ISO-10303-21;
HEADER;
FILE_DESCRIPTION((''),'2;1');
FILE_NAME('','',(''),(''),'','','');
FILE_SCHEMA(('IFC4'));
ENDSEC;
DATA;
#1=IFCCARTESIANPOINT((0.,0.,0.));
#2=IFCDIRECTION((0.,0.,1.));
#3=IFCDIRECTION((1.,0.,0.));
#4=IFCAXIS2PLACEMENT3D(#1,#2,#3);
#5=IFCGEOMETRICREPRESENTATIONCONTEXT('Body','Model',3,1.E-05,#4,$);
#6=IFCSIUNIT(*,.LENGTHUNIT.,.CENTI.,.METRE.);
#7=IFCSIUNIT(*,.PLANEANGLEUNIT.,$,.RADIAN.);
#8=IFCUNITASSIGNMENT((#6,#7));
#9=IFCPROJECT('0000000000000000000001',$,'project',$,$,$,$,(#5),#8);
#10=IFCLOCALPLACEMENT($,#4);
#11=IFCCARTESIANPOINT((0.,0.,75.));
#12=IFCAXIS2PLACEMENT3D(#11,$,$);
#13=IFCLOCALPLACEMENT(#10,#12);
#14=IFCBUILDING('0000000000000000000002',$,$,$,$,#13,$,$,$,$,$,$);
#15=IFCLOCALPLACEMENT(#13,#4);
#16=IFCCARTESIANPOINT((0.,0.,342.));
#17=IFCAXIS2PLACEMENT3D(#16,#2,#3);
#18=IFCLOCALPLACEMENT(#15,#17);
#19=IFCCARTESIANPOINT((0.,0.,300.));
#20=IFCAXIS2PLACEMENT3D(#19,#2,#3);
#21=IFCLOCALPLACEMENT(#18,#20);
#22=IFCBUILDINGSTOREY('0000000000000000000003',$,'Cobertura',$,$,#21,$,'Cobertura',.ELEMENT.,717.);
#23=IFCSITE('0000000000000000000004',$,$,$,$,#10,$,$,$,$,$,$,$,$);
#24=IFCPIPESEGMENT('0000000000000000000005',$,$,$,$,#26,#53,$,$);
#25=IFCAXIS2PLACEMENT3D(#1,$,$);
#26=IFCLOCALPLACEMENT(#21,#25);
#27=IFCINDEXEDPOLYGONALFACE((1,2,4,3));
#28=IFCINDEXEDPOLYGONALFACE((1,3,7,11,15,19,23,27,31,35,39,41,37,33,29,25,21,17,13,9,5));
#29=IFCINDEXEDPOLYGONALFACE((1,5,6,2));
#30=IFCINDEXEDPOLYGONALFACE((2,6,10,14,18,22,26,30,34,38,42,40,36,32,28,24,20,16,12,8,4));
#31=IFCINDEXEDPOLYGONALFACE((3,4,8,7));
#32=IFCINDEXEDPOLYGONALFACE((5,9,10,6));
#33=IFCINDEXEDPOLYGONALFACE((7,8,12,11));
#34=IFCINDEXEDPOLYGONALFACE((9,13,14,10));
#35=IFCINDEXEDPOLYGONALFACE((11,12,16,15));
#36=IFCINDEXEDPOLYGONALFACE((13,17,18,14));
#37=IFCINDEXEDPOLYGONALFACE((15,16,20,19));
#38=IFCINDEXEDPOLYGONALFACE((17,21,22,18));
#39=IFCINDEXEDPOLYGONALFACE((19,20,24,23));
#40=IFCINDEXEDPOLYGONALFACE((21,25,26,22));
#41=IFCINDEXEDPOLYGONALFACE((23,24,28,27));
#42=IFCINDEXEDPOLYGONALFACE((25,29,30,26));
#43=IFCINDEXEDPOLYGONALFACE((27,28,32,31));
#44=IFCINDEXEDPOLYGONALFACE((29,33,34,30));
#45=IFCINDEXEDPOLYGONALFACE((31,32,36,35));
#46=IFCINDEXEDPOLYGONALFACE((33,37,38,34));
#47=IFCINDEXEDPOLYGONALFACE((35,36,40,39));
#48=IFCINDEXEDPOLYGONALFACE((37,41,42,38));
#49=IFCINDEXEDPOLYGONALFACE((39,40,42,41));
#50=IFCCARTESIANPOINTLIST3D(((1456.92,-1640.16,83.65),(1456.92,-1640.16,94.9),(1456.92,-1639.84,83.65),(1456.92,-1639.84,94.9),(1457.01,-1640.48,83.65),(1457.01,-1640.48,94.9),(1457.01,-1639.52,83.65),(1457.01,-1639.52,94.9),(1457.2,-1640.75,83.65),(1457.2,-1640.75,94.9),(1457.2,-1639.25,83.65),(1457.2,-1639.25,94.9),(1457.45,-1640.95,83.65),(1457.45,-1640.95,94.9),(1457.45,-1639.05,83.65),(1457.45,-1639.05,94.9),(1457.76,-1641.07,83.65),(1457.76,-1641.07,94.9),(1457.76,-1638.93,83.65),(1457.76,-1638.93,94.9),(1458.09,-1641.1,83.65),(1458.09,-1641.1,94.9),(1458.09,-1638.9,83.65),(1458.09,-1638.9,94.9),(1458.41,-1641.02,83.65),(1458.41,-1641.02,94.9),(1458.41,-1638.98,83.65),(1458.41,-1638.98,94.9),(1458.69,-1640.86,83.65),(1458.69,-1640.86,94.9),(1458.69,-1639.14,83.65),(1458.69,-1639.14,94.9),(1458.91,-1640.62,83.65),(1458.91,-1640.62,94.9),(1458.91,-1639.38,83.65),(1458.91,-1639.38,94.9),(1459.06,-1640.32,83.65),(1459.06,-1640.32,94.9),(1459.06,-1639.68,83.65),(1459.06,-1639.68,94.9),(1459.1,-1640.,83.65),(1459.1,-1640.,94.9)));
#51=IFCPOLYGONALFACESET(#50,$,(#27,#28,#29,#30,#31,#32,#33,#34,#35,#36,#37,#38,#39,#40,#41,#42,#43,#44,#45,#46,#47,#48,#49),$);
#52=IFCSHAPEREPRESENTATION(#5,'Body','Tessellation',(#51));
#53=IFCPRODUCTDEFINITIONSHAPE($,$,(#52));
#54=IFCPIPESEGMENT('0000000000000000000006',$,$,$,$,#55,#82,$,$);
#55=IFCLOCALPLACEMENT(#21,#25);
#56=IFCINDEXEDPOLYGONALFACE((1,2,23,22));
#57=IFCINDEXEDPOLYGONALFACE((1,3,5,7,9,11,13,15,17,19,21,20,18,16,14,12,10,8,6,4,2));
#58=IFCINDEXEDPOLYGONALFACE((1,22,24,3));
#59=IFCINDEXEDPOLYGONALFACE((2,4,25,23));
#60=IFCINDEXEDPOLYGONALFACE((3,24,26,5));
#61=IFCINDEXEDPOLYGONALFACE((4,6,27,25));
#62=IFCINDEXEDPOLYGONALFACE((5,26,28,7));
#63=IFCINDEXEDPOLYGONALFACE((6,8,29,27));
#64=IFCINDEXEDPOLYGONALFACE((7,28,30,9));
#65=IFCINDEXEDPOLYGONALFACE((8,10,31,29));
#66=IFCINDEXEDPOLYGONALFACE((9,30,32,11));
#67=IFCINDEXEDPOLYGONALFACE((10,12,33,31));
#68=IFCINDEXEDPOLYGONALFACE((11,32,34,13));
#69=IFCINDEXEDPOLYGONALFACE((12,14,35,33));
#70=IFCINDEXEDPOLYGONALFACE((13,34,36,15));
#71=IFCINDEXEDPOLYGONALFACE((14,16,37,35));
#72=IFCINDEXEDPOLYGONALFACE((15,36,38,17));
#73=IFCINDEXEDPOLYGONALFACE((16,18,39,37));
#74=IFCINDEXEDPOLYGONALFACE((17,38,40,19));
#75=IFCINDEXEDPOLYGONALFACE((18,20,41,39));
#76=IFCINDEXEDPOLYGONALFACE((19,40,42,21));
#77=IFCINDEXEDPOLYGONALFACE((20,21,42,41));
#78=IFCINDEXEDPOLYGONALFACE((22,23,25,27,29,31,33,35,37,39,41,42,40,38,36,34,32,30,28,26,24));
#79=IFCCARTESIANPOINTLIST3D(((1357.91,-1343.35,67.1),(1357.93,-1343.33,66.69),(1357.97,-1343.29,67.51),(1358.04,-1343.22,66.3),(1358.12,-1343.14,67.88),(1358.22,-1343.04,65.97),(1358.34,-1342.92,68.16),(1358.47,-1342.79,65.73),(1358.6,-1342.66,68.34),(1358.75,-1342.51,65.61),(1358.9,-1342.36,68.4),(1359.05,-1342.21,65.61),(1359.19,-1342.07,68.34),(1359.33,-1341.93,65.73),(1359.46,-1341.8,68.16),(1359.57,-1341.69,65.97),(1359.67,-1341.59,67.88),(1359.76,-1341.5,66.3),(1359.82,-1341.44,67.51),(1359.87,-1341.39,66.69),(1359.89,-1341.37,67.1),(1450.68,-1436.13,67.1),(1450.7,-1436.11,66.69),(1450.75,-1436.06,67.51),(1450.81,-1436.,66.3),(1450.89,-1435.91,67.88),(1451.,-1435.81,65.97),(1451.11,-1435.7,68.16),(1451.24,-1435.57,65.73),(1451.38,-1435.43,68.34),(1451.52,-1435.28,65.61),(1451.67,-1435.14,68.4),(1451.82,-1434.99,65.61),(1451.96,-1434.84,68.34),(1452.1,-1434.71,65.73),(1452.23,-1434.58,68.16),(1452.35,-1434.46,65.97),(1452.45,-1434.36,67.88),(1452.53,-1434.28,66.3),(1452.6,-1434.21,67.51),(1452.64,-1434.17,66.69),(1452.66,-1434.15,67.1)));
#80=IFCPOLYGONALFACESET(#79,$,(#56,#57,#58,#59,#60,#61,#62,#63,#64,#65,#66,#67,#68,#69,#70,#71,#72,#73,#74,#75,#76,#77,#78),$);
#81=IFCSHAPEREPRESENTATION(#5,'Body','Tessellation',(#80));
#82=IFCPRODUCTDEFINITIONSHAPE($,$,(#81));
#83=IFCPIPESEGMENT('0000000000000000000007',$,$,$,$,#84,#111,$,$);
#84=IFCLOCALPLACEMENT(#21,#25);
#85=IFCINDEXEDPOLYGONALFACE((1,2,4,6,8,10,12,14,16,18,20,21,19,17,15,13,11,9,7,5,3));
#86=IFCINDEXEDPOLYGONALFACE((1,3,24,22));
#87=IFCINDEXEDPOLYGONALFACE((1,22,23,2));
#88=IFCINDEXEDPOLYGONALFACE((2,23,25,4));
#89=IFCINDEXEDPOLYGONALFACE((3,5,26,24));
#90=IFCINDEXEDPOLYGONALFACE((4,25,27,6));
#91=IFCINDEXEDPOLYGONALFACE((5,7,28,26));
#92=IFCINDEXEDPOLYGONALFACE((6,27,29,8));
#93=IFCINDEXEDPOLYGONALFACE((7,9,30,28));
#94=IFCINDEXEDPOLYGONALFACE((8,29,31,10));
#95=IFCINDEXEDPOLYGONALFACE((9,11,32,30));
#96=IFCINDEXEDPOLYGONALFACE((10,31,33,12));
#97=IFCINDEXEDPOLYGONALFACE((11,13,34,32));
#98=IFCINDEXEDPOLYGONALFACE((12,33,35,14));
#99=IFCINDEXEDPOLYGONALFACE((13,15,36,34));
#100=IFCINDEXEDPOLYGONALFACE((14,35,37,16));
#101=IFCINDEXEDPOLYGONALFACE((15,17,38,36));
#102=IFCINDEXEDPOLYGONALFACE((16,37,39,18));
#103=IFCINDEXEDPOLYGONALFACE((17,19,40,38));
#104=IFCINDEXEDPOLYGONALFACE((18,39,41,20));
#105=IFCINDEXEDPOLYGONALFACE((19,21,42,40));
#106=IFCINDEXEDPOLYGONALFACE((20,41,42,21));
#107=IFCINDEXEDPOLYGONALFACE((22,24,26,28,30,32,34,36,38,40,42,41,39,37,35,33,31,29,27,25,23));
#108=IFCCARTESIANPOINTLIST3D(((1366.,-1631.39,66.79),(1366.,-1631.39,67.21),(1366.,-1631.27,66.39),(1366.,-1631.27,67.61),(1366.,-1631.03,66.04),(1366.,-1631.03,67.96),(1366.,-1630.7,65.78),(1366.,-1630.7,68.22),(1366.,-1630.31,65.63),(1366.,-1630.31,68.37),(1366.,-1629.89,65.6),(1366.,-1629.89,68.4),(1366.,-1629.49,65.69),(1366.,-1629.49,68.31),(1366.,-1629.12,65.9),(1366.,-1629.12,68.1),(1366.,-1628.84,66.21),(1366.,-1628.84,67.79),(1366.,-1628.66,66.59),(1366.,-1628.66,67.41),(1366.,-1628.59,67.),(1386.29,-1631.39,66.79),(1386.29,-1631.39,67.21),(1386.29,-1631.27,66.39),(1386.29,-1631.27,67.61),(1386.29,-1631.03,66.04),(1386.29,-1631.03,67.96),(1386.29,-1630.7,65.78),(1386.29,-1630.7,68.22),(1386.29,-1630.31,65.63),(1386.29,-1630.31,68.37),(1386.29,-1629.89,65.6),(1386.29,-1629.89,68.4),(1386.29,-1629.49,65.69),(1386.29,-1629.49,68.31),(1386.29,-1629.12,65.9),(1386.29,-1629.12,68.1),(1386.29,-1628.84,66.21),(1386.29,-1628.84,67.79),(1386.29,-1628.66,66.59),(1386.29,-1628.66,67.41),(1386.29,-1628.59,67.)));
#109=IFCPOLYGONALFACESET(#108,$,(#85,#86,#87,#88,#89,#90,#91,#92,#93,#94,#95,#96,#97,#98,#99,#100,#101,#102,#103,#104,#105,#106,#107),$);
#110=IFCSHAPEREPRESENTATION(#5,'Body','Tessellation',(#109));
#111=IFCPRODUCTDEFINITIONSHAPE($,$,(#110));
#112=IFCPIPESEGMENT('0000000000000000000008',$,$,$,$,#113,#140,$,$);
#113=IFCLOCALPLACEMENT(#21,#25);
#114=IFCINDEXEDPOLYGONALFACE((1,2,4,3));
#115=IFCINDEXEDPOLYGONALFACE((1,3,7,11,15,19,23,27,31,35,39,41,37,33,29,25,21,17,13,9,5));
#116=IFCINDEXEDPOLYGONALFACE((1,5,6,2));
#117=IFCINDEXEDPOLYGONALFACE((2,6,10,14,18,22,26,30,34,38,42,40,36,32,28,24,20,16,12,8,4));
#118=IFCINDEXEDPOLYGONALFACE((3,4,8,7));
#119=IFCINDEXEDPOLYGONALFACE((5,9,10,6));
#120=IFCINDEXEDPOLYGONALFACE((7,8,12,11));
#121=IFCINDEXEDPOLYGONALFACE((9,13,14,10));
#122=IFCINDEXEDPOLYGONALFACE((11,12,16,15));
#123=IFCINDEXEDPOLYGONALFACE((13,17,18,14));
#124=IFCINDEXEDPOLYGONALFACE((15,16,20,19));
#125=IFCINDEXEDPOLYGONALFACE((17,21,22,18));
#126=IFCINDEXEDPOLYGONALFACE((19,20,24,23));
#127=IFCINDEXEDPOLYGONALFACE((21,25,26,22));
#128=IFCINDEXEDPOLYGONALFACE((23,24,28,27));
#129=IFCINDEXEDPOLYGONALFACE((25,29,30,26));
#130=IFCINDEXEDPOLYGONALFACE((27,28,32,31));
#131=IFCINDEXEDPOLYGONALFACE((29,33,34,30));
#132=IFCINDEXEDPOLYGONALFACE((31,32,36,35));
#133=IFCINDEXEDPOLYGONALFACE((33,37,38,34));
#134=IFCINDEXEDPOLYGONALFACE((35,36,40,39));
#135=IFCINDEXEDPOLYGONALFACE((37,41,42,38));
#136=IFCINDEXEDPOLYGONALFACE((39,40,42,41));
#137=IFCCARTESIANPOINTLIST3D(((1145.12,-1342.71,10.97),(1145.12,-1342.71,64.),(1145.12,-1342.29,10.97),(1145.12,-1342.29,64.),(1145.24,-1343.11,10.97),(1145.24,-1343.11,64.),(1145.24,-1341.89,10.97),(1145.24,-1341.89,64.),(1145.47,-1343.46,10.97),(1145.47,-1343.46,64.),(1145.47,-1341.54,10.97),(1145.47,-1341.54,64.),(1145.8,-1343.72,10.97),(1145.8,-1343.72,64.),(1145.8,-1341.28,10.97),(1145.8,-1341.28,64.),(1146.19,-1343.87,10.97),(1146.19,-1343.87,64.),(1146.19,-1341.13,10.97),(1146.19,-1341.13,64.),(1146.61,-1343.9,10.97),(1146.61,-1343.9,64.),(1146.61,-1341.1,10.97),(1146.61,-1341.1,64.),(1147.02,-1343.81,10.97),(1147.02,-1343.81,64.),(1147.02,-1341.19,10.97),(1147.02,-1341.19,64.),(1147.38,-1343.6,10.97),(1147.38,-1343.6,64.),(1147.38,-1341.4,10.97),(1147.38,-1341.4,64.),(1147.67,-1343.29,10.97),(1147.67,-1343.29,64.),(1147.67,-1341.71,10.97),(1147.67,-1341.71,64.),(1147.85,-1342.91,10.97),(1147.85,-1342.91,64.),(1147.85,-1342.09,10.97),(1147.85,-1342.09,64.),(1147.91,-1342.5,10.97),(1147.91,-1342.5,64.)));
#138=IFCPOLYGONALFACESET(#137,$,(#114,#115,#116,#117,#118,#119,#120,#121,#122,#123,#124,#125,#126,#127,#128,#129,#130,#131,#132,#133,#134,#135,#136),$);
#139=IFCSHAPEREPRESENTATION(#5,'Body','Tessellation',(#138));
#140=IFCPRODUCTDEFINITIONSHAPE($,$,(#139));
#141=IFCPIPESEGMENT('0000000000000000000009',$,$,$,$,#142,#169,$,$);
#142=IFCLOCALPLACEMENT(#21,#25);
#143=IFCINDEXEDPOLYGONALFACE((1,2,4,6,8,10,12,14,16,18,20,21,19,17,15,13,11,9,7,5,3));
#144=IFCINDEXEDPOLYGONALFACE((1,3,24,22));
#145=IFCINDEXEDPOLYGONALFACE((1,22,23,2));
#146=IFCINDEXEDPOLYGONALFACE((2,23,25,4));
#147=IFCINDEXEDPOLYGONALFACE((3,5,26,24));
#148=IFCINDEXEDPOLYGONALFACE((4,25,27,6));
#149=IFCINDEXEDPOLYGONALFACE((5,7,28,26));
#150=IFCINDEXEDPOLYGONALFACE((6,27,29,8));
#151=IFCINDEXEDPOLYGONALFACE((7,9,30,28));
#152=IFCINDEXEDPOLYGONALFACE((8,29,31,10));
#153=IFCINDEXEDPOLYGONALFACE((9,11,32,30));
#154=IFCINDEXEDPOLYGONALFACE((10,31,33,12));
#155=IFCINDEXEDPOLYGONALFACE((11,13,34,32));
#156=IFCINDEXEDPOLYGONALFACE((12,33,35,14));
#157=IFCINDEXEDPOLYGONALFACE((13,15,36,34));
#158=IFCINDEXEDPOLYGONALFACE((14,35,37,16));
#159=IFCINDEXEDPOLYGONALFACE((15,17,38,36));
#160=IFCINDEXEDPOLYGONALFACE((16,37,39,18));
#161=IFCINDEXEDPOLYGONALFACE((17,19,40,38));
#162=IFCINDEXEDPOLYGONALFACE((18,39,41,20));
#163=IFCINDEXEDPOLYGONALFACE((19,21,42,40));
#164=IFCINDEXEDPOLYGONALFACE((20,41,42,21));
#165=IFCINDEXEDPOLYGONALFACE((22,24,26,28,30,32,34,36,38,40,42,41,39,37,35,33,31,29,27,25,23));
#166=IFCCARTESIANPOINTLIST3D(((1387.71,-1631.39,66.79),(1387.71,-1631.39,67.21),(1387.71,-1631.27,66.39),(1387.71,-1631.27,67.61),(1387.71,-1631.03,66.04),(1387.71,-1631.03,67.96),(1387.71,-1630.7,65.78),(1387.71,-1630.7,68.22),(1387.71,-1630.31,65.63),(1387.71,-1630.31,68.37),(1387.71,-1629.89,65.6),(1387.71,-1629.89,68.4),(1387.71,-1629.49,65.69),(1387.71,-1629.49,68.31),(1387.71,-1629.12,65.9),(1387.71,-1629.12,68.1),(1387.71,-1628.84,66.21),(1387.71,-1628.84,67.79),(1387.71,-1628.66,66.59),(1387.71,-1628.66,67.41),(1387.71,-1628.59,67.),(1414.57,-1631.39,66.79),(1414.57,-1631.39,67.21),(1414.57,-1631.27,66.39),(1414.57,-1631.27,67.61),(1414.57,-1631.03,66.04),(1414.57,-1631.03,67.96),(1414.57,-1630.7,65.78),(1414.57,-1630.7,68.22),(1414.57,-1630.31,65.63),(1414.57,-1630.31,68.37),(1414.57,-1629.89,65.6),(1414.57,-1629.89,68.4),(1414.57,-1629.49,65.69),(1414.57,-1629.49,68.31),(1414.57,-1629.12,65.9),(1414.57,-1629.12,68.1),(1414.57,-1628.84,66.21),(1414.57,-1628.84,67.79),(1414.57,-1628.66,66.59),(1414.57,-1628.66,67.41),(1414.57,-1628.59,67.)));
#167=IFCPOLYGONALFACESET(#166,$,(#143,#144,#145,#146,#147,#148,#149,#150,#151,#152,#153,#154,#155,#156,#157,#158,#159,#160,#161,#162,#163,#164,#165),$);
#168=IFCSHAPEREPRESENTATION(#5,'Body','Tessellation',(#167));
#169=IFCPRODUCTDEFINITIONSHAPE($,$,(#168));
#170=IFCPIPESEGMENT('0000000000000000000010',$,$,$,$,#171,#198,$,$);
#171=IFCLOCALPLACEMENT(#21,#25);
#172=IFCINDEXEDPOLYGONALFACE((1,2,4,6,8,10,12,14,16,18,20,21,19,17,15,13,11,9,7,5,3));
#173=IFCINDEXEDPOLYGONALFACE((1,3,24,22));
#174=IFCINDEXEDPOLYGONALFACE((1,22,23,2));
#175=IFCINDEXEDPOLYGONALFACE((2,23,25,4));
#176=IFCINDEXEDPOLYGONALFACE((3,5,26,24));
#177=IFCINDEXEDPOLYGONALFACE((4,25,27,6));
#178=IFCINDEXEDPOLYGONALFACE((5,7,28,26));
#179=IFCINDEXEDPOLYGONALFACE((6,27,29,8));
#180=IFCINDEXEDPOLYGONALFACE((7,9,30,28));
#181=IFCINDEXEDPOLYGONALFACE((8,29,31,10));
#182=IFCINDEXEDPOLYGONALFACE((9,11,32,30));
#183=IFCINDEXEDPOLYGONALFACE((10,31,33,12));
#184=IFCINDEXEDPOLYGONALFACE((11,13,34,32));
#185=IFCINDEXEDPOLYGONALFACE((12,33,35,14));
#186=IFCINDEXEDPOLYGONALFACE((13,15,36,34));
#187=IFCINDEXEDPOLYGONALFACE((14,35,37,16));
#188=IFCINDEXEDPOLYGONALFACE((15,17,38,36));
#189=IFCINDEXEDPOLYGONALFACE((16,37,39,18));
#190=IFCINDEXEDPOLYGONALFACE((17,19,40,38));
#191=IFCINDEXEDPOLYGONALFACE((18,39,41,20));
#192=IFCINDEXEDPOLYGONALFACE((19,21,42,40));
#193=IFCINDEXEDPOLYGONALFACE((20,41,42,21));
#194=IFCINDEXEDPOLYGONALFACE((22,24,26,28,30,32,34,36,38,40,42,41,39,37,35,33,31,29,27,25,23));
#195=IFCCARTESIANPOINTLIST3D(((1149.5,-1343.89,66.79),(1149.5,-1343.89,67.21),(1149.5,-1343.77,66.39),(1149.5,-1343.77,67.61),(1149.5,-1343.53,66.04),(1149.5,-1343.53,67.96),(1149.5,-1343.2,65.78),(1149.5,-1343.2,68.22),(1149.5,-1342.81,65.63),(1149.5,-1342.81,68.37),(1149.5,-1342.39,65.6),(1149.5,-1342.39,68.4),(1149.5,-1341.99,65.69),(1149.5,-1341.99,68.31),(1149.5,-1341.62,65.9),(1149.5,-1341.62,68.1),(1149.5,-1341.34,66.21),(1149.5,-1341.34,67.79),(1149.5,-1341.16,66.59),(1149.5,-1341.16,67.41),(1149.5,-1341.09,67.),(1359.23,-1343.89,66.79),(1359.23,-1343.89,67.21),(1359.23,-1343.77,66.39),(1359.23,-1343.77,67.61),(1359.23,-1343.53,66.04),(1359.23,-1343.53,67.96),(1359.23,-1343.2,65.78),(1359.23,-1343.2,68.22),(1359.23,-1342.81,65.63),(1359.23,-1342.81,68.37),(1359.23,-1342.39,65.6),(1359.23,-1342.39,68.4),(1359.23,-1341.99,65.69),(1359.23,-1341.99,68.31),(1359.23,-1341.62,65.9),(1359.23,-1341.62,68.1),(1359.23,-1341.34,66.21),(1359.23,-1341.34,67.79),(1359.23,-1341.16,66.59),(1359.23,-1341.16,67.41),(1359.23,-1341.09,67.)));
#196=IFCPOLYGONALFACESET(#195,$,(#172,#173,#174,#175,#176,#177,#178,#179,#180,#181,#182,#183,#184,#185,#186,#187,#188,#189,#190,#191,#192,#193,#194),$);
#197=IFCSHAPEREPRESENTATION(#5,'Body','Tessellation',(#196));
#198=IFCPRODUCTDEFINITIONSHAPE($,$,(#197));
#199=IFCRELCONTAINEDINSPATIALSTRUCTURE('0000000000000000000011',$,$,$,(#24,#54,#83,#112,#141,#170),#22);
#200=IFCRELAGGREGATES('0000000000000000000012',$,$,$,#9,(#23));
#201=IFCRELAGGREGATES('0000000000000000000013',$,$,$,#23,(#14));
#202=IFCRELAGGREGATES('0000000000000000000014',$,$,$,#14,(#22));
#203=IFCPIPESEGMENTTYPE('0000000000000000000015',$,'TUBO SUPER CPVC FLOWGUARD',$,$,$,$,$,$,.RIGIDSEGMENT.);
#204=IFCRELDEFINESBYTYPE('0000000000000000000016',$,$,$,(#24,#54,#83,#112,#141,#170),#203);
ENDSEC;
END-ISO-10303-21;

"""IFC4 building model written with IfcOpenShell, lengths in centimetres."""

from ifc_helpers import new_model, si_unit, frame, origin_with_axes, origin_2d_with_axis, place, context, project, spatial, circle, extrude, type_object, element, save


model = new_model("IFC4")

# Units and contexts
model_context = context("Model", 3, precision=1e-05, world=origin_with_axes(), identifier="Body")
ifc_project = project(units=[si_unit("LENGTHUNIT", "METRE", prefix="CENTI"), si_unit("PLANEANGLEUNIT", "RADIAN")], contexts=[model_context])

# Site, building, storey
site_placement = place(None, origin_with_axes())
site = spatial("IfcSite", under=ifc_project, at=site_placement)
building_placement = place(site_placement, frame((0.0, 0.0, 75.0)))
building = spatial("IfcBuilding", under=site, at=building_placement)
placement_1 = place(building_placement, origin_with_axes())
placement_2 = place(placement_1, frame((0.0, 0.0, 342.0), z_axis=(0.0, 0.0, 1.0), x_axis=(1.0, 0.0, 0.0)))
storey_placement = place(placement_2, frame((0.0, 0.0, 300.0), z_axis=(0.0, 0.0, 1.0), x_axis=(1.0, 0.0, 0.0)))
storey = spatial("IfcBuildingStorey", under=building, at=storey_placement, Name="Cobertura", LongName="Cobertura", CompositionType="ELEMENT", Elevation=717.0)

# Pipe segments
pipe_segment_type_1 = type_object("IfcPipeSegmentType", Name="TUBO SUPER CPVC FLOWGUARD", PredefinedType="RIGIDSEGMENT")
pipe_segment_1_placement = place(storey_placement, frame((1458.0, -1640.0, 94.9), z_axis=(0.0, 0.0, 1.0), x_axis=(1.0, 0.0, 0.0)))
element("IfcPipeSegment", 1, at=pipe_segment_1_placement, inside=storey, type_object=pipe_segment_type_1, context=model_context, shape_type="SolidModel", body=[
    extrude(circle(Radius=1.1, at=origin_2d_with_axis()), frame((0.0, 0.0, -11.25), z_axis=(0.0, 0.0, 1.0), x_axis=(1.0, 0.0, 0.0)), (0.0, 0.0, 1.0), 11.25),
])
pipe_segment_2_placement = place(storey_placement, frame((1405.28, -1388.75, 68.41), z_axis=(0.0, 0.0, 1.0), x_axis=(1.0, 0.0, 0.0)))
element("IfcPipeSegment", 2, at=pipe_segment_2_placement, inside=storey, type_object=pipe_segment_type_1, context=model_context, shape_type="SolidModel", body=[
    extrude(circle(Radius=1.41, at=origin_2d_with_axis()), frame((46.39, -46.39, -1.41), z_axis=(-0.707107, 0.707107, 0.0), x_axis=(0.0, 0.0, 1.0)), (0.0, 0.0, 1.0), 131.2),
])
pipe_segment_3_placement = place(storey_placement, frame((1376.15, -1630.0, 68.41), z_axis=(0.0, 0.0, 1.0), x_axis=(1.0, 0.0, 0.0)))
element("IfcPipeSegment", 3, at=pipe_segment_3_placement, inside=storey, type_object=pipe_segment_type_1, context=model_context, shape_type="SolidModel", body=[
    extrude(circle(Radius=1.41, at=origin_2d_with_axis()), frame((-10.15, 0.0, -1.41), z_axis=(1.0, 0.0, 0.0), x_axis=(0.0, 1.0, 0.0)), (0.0, 0.0, 1.0), 20.29),
])
pipe_segment_4_placement = place(storey_placement, frame((1146.5, -1342.5, 64.0), z_axis=(0.0, 0.0, 1.0), x_axis=(1.0, 0.0, 0.0)))
element("IfcPipeSegment", 4, at=pipe_segment_4_placement, inside=storey, type_object=pipe_segment_type_1, context=model_context, shape_type="SolidModel", body=[
    extrude(circle(Radius=1.41, at=origin_2d_with_axis()), frame((0.0, 0.0, 0.0), z_axis=(0.0, 0.0, -1.0), x_axis=(1.0, 0.0, 0.0)), (0.0, 0.0, 1.0), 53.03),
])
pipe_segment_5_placement = place(storey_placement, frame((1401.14, -1630.0, 68.41), z_axis=(0.0, 0.0, 1.0), x_axis=(1.0, 0.0, 0.0)))
element("IfcPipeSegment", 5, at=pipe_segment_5_placement, inside=storey, type_object=pipe_segment_type_1, context=model_context, shape_type="SolidModel", body=[
    extrude(circle(Radius=1.41, at=origin_2d_with_axis()), frame((-13.43, 0.0, -1.41), z_axis=(1.0, 0.0, 0.0), x_axis=(0.0, 1.0, 0.0)), (0.0, 0.0, 1.0), 26.86),
])
pipe_segment_6_placement = place(storey_placement, frame((1254.37, -1342.5, 68.41), z_axis=(0.0, 0.0, 1.0), x_axis=(1.0, 0.0, 0.0)))
element("IfcPipeSegment", 6, at=pipe_segment_6_placement, inside=storey, type_object=pipe_segment_type_1, context=model_context, shape_type="SolidModel", body=[
    extrude(circle(Radius=1.41, at=origin_2d_with_axis()), frame((104.86, 0.0, -1.41), z_axis=(-1.0, 0.0, 0.0), x_axis=(0.0, 1.0, 0.0)), (0.0, 0.0, 1.0), 209.72),
])

save(model, "model.ifc")
